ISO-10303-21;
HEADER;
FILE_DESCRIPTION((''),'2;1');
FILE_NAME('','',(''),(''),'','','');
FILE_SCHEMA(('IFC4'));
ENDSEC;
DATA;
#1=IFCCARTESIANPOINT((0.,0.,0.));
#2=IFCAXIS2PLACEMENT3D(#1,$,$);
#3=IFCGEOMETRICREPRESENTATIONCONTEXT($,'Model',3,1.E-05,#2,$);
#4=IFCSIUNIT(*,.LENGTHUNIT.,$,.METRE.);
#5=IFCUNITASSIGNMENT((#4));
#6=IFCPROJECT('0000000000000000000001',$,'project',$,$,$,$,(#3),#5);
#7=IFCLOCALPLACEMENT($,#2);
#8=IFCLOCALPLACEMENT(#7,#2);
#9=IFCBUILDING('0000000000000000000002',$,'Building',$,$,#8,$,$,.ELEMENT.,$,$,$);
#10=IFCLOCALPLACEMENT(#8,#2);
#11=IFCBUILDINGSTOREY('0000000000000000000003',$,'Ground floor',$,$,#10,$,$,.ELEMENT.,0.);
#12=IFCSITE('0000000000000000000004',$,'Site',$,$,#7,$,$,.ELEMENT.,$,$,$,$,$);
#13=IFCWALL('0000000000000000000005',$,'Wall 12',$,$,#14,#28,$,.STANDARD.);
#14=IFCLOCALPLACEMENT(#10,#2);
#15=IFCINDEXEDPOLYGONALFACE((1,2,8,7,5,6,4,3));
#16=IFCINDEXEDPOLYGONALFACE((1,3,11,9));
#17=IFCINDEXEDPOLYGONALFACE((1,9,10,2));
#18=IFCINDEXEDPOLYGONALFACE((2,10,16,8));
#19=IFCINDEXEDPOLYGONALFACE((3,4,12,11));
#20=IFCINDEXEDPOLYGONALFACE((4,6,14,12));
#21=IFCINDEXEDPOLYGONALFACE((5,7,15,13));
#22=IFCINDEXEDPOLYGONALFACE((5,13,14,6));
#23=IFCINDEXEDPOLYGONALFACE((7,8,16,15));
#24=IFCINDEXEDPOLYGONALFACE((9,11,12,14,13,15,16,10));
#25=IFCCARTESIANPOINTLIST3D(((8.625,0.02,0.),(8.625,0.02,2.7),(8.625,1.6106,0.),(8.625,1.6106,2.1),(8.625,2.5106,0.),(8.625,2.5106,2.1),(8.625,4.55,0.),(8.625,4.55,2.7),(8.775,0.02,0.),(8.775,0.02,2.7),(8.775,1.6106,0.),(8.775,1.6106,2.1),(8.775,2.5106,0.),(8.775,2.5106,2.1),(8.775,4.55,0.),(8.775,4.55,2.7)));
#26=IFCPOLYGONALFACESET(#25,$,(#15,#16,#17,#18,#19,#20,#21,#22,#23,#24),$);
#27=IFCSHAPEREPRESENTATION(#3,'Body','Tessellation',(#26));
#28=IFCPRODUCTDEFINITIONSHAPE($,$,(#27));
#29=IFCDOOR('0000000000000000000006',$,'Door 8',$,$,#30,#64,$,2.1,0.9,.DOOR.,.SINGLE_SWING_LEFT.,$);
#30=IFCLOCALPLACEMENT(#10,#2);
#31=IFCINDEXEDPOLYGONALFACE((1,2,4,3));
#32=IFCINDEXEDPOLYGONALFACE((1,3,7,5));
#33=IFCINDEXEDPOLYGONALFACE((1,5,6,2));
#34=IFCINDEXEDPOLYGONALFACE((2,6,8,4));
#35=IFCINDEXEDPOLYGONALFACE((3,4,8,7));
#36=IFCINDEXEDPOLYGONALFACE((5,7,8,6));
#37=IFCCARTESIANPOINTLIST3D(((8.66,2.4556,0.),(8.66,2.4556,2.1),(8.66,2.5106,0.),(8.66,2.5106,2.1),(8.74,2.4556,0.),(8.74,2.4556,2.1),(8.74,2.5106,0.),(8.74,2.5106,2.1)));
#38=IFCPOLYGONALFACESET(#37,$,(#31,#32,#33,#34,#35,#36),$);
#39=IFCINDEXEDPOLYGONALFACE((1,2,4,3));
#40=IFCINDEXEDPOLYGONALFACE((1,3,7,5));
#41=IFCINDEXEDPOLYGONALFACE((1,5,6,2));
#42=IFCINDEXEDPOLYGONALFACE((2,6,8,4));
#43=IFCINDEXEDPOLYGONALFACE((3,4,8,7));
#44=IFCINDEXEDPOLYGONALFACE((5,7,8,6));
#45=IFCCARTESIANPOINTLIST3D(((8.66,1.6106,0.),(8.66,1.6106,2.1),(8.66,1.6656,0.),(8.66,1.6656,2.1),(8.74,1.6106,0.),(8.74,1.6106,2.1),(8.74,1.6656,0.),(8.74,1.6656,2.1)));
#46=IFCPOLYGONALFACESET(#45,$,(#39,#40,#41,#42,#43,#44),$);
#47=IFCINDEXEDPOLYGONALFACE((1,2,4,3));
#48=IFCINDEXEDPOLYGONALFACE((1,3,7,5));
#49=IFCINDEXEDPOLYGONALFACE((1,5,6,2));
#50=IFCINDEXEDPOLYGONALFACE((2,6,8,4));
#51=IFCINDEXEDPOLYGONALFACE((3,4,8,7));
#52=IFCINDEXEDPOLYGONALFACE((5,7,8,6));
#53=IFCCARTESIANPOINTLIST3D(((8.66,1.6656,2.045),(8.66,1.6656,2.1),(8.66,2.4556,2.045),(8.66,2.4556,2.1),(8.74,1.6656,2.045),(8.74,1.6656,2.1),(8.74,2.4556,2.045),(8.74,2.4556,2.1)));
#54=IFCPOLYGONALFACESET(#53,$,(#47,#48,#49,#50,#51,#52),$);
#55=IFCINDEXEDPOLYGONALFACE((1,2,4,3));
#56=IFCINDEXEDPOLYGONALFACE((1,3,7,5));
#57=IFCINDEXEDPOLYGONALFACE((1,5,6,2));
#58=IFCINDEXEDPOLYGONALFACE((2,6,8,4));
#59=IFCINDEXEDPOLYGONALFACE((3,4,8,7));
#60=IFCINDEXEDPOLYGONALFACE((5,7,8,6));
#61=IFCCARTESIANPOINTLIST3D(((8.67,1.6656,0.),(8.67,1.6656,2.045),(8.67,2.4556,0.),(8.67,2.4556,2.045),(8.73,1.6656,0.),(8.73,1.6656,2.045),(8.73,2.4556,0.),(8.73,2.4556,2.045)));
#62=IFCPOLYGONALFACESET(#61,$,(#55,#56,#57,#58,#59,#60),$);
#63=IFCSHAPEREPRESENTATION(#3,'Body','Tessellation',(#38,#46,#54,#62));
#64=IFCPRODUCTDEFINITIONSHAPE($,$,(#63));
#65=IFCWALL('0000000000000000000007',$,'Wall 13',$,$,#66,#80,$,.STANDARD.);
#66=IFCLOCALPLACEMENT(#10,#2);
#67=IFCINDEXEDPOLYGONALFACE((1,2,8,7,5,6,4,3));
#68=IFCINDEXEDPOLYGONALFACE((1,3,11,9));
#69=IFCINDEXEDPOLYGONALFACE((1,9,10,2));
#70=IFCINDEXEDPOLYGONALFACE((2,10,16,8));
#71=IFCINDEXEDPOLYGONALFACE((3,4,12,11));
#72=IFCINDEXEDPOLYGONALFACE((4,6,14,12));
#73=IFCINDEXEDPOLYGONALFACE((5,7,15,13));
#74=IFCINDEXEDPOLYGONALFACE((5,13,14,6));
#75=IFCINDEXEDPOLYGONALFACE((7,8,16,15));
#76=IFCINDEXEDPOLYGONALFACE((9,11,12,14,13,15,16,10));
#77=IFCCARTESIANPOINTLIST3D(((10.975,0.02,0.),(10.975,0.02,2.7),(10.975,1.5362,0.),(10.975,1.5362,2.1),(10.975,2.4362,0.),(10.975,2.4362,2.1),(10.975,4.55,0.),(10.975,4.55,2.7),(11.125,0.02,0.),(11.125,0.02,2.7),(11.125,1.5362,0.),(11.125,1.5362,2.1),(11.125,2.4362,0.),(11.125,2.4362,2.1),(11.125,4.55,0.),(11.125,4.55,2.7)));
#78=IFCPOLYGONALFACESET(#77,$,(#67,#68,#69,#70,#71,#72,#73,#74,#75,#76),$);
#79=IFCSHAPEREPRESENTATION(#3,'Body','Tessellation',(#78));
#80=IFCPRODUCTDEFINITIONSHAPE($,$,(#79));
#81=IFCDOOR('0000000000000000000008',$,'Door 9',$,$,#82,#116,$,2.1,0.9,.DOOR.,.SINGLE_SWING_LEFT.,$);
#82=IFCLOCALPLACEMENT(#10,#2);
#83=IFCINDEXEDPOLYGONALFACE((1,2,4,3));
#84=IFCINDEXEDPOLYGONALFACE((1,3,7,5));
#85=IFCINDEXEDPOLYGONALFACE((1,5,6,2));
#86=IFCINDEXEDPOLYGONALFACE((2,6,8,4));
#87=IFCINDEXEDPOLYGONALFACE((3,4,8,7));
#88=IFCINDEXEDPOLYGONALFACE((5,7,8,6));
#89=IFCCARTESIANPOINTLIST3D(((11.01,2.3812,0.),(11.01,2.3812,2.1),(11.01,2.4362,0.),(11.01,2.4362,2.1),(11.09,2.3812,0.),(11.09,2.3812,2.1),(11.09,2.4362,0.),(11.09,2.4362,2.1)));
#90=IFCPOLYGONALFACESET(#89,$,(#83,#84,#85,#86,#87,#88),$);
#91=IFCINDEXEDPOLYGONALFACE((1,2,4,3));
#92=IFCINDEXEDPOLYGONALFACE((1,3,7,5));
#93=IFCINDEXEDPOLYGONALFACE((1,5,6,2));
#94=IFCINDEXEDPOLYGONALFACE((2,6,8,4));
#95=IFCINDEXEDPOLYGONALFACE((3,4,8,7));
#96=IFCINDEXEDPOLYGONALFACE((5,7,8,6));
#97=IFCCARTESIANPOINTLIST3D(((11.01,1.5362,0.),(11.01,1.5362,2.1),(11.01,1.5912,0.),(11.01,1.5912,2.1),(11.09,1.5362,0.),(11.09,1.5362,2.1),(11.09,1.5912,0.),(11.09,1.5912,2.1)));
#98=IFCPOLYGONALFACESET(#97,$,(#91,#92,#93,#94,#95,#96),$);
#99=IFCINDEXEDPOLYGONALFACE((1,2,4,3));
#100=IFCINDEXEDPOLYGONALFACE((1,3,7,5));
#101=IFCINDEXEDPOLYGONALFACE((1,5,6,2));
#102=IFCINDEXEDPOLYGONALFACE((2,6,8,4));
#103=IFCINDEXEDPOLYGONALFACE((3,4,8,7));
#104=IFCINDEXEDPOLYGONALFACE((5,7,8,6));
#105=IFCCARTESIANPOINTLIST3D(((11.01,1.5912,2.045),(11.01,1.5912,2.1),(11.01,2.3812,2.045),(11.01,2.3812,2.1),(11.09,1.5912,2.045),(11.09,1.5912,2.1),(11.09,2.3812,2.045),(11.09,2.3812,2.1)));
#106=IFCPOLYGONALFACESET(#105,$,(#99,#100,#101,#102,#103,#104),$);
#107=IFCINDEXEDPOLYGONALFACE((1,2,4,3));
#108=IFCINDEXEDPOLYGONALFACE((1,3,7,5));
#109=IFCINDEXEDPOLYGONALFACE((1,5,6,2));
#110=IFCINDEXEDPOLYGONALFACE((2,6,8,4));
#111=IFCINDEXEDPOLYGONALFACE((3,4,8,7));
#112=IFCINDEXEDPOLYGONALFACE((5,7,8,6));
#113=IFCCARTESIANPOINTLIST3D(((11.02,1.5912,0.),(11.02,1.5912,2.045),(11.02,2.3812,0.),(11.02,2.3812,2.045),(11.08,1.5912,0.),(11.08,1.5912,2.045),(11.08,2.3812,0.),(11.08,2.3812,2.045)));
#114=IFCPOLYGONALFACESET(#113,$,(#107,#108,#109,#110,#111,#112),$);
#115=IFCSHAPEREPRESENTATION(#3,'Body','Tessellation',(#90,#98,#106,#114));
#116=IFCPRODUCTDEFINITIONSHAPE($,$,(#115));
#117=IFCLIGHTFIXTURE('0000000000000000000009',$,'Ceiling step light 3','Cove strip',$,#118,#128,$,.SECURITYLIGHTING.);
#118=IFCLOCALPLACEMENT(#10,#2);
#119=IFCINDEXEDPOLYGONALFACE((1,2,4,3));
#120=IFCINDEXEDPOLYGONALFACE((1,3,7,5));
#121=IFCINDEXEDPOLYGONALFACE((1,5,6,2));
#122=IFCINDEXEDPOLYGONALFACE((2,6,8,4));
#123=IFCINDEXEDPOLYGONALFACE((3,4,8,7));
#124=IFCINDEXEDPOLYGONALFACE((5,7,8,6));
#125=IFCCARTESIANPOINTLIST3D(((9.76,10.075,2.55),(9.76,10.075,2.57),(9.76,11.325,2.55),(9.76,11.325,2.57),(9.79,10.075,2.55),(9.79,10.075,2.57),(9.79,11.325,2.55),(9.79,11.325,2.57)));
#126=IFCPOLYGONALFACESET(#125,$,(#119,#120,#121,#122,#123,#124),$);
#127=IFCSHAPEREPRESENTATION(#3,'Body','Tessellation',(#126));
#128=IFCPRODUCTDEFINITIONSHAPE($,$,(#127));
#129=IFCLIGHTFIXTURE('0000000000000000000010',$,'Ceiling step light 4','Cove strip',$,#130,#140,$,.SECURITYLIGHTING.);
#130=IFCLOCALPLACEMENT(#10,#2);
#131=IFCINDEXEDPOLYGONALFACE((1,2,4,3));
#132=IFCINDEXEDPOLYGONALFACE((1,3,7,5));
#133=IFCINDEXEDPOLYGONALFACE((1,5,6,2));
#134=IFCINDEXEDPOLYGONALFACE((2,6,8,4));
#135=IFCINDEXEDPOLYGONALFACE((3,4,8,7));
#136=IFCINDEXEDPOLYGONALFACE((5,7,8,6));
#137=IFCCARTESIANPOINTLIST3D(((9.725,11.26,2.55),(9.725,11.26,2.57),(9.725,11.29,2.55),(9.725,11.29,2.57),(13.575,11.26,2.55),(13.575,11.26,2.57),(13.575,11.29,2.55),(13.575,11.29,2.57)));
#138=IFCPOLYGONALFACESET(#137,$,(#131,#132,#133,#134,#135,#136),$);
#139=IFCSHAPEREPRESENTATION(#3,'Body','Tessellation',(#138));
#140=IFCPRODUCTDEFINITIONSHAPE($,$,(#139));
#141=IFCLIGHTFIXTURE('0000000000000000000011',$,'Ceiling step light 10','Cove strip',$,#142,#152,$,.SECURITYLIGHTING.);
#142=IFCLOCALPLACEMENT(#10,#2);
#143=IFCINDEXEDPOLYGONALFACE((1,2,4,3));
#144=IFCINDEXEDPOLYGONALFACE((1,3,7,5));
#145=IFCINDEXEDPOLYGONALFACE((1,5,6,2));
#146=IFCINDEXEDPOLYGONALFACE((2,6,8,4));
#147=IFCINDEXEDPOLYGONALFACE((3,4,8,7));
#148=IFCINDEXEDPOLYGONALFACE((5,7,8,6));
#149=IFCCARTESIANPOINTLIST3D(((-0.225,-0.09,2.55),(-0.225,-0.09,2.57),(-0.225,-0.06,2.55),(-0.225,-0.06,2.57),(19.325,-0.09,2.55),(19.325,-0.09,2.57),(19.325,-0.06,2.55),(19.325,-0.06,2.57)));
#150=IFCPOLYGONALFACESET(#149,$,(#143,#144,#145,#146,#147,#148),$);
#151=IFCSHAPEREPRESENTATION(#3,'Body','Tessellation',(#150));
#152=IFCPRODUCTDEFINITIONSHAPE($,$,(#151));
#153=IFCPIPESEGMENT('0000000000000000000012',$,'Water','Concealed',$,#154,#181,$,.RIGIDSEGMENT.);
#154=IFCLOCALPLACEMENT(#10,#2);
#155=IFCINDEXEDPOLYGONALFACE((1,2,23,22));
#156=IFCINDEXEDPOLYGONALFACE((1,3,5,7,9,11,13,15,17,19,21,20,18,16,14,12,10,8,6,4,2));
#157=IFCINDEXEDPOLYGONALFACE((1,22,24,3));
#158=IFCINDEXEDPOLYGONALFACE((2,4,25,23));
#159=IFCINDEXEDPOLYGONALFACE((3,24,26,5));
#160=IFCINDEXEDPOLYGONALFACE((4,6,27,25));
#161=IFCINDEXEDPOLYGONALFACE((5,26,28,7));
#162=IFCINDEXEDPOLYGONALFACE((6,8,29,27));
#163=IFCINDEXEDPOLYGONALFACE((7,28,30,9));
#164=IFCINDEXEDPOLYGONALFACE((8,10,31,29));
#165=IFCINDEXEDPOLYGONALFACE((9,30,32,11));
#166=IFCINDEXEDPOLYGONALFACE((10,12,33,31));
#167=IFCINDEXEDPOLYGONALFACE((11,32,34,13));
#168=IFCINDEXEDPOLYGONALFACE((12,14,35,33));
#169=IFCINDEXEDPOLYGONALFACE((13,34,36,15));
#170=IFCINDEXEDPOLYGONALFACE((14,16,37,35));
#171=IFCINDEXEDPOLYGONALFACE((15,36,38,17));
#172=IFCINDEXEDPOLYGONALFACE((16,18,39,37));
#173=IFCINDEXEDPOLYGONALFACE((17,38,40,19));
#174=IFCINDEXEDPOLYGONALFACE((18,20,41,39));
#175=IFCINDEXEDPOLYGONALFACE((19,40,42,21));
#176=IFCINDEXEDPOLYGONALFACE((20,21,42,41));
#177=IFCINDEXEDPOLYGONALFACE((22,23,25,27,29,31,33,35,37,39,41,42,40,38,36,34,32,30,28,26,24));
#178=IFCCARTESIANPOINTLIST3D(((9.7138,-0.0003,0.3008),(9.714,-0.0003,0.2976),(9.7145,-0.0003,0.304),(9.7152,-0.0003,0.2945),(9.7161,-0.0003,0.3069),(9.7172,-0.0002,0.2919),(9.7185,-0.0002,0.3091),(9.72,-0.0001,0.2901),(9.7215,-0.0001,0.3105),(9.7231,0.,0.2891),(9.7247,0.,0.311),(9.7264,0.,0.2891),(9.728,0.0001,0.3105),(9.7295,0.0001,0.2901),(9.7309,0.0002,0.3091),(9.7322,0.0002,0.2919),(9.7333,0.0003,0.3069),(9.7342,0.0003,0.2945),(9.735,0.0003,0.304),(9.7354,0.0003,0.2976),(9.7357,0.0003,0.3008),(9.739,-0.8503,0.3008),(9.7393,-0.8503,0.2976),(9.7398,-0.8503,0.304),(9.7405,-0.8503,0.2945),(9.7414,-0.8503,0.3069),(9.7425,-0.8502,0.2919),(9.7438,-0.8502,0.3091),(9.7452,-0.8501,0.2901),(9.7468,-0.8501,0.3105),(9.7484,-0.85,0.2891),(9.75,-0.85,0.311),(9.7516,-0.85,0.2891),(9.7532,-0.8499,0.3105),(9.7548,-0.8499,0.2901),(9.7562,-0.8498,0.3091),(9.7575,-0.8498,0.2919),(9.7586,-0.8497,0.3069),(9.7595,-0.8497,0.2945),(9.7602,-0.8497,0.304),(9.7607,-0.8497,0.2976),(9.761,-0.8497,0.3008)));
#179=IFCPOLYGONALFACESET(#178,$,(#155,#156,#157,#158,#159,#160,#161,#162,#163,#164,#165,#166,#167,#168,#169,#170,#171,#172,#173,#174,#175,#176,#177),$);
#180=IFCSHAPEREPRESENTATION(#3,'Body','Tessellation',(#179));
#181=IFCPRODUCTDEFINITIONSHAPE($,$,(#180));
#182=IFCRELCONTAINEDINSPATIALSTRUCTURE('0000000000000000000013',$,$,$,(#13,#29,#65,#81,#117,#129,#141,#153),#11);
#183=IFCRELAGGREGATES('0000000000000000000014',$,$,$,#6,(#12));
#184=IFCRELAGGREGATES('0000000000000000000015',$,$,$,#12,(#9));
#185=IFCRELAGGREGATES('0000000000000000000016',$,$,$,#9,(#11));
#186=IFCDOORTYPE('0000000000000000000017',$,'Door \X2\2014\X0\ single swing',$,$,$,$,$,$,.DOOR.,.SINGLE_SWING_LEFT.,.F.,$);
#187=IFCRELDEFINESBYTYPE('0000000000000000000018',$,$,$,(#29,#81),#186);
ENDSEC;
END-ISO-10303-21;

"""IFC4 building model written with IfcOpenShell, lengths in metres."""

from ifc_helpers import new_model, si_unit, frame, frame_2d, origin, origin_2d, place, context, project, spatial, rectangle, circle, extrude, type_object, element, fill, save


model = new_model("IFC4")

# Units and contexts
model_context = context("Model", 3, precision=1e-05, world=origin())
ifc_project = project(units=[si_unit("LENGTHUNIT", "METRE")], contexts=[model_context])

# Site, building, storey
site_placement = place(None, origin())
site = spatial("IfcSite", under=ifc_project, at=site_placement, Name="Site", CompositionType="ELEMENT")
building_placement = place(site_placement, origin())
building = spatial("IfcBuilding", under=site, at=building_placement, Name="Building", CompositionType="ELEMENT")
storey_placement = place(building_placement, origin())
storey = spatial("IfcBuildingStorey", under=building, at=storey_placement, Name="Ground floor", CompositionType="ELEMENT", Elevation=0.0)

# Walls, openings, doors
wall_1_placement = place(storey_placement, frame((8.7, 4.55, 0.0), z_axis=(0.0, 0.0, 1.0), x_axis=(0.0, -1.0, 0.0)))
wall_1 = element("IfcWall", 1, at=wall_1_placement, inside=storey, Name="Wall 12", PredefinedType="STANDARD", context=model_context, shape_type="SweptSolid", body=[
    extrude(rectangle(XDim=4.53, YDim=0.15, at=frame_2d((2.265, 0.0))), origin(), (0.0, 0.0, 1.0), 2.7),
])
opening_1_placement = place(storey_placement, frame((8.7, 2.5106, 0.0), z_axis=(0.0, 0.0, 1.0), x_axis=(0.0, -1.0, 0.0)))
opening_1 = element("IfcOpeningElement", 2, at=opening_1_placement, cuts=wall_1, PredefinedType="OPENING", context=model_context, shape_type="SweptSolid", body=[
    extrude(rectangle(XDim=0.9, YDim=0.21, at=frame_2d((0.45, 0.0))), origin(), (0.0, 0.0, 1.0), 2.1),
])
door_type = type_object("IfcDoorType", Name="Door — single swing", OperationType="SINGLE_SWING_LEFT", ParameterTakesPrecedence=False, PredefinedType="DOOR")
door_1_placement = place(storey_placement, frame((8.7, 2.5106, 0.0), z_axis=(0.0, 0.0, 1.0), x_axis=(0.0, -1.0, 0.0)))
door_1 = element("IfcDoor", 3, at=door_1_placement, inside=storey, type_object=door_type, Name="Door 8", OperationType="SINGLE_SWING_LEFT", OverallHeight=2.1, OverallWidth=0.9, PredefinedType="DOOR", context=model_context, shape_type="SweptSolid", body=[
    extrude(rectangle(XDim=0.055, YDim=0.08, at=frame_2d((0.0275, 0.0))), origin(), (0.0, 0.0, 1.0), 2.1),
    extrude(rectangle(XDim=0.055, YDim=0.08, at=frame_2d((0.8725, 0.0))), origin(), (0.0, 0.0, 1.0), 2.1),
    extrude(rectangle(XDim=0.79, YDim=0.08, at=frame_2d((0.45, 0.0))), frame((0.0, 0.0, 2.045)), (0.0, 0.0, 1.0), 0.055),
    extrude(rectangle(XDim=0.79, YDim=0.06, at=frame_2d((0.45, 0.0))), origin(), (0.0, 0.0, 1.0), 2.045),
])
fill(opening_1, door_1)
wall_2_placement = place(storey_placement, frame((11.05, 4.55, 0.0), z_axis=(0.0, 0.0, 1.0), x_axis=(0.0, -1.0, 0.0)))
wall_2 = element("IfcWall", 4, at=wall_2_placement, inside=storey, Name="Wall 13", PredefinedType="STANDARD", context=model_context, shape_type="SweptSolid", body=[
    extrude(rectangle(XDim=4.53, YDim=0.15, at=frame_2d((2.265, 0.0))), origin(), (0.0, 0.0, 1.0), 2.7),
])
opening_2_placement = place(storey_placement, frame((11.05, 2.4362, 0.0), z_axis=(0.0, 0.0, 1.0), x_axis=(0.0, -1.0, 0.0)))
opening_2 = element("IfcOpeningElement", 5, at=opening_2_placement, cuts=wall_2, PredefinedType="OPENING", context=model_context, shape_type="SweptSolid", body=[
    extrude(rectangle(XDim=0.9, YDim=0.21, at=frame_2d((0.45, 0.0))), origin(), (0.0, 0.0, 1.0), 2.1),
])
door_2_placement = place(storey_placement, frame((11.05, 2.4362, 0.0), z_axis=(0.0, 0.0, 1.0), x_axis=(0.0, -1.0, 0.0)))
door_2 = element("IfcDoor", 6, at=door_2_placement, inside=storey, type_object=door_type, Name="Door 9", OperationType="SINGLE_SWING_LEFT", OverallHeight=2.1, OverallWidth=0.9, PredefinedType="DOOR", context=model_context, shape_type="SweptSolid", body=[
    extrude(rectangle(XDim=0.055, YDim=0.08, at=frame_2d((0.0275, 0.0))), origin(), (0.0, 0.0, 1.0), 2.1),
    extrude(rectangle(XDim=0.055, YDim=0.08, at=frame_2d((0.8725, 0.0))), origin(), (0.0, 0.0, 1.0), 2.1),
    extrude(rectangle(XDim=0.79, YDim=0.08, at=frame_2d((0.45, 0.0))), frame((0.0, 0.0, 2.045)), (0.0, 0.0, 1.0), 0.055),
    extrude(rectangle(XDim=0.79, YDim=0.06, at=frame_2d((0.45, 0.0))), origin(), (0.0, 0.0, 1.0), 2.045),
])
fill(opening_2, door_2)

# Light fixtures
light_fixture_1_placement = place(storey_placement, frame((9.775, 10.7, 2.55), z_axis=(0.0, 0.0, 1.0), x_axis=(0.0, 1.0, 0.0)))
element("IfcLightFixture", 7, at=light_fixture_1_placement, inside=storey, Name="Ceiling step light 3", Description="Cove strip", PredefinedType="SECURITYLIGHTING", context=model_context, shape_type="SweptSolid", body=[
    extrude(rectangle(XDim=1.25, YDim=0.03, at=origin_2d()), origin(), (0.0, 0.0, 1.0), 0.02),
])
light_fixture_2_placement = place(storey_placement, frame((11.65, 11.275, 2.55), z_axis=(0.0, 0.0, 1.0), x_axis=(1.0, 0.0, 0.0)))
element("IfcLightFixture", 8, at=light_fixture_2_placement, inside=storey, Name="Ceiling step light 4", Description="Cove strip", PredefinedType="SECURITYLIGHTING", context=model_context, shape_type="SweptSolid", body=[
    extrude(rectangle(XDim=3.85, YDim=0.03, at=origin_2d()), origin(), (0.0, 0.0, 1.0), 0.02),
])
light_fixture_3_placement = place(storey_placement, frame((9.55, -0.075, 2.55), z_axis=(0.0, 0.0, 1.0), x_axis=(-1.0, 0.0, 0.0)))
element("IfcLightFixture", 9, at=light_fixture_3_placement, inside=storey, Name="Ceiling step light 10", Description="Cove strip", PredefinedType="SECURITYLIGHTING", context=model_context, shape_type="SweptSolid", body=[
    extrude(rectangle(XDim=19.55, YDim=0.03, at=origin_2d()), origin(), (0.0, 0.0, 1.0), 0.02),
])

# Pipe segment
pipe_segment_1_placement = place(storey_placement, frame((9.75, -0.85, 0.3), z_axis=(-0.02972, 0.999558, 0.0), x_axis=(0.0, 0.0, 1.0)))
element("IfcPipeSegment", 10, at=pipe_segment_1_placement, inside=storey, Name="Water", Description="Concealed", PredefinedType="RIGIDSEGMENT", context=model_context, shape_type="SweptSolid", body=[
    extrude(circle(Radius=0.011, at=origin_2d()), origin(), (0.0, 0.0, 1.0), 0.8504),
])

save(model, "model.ifc")
